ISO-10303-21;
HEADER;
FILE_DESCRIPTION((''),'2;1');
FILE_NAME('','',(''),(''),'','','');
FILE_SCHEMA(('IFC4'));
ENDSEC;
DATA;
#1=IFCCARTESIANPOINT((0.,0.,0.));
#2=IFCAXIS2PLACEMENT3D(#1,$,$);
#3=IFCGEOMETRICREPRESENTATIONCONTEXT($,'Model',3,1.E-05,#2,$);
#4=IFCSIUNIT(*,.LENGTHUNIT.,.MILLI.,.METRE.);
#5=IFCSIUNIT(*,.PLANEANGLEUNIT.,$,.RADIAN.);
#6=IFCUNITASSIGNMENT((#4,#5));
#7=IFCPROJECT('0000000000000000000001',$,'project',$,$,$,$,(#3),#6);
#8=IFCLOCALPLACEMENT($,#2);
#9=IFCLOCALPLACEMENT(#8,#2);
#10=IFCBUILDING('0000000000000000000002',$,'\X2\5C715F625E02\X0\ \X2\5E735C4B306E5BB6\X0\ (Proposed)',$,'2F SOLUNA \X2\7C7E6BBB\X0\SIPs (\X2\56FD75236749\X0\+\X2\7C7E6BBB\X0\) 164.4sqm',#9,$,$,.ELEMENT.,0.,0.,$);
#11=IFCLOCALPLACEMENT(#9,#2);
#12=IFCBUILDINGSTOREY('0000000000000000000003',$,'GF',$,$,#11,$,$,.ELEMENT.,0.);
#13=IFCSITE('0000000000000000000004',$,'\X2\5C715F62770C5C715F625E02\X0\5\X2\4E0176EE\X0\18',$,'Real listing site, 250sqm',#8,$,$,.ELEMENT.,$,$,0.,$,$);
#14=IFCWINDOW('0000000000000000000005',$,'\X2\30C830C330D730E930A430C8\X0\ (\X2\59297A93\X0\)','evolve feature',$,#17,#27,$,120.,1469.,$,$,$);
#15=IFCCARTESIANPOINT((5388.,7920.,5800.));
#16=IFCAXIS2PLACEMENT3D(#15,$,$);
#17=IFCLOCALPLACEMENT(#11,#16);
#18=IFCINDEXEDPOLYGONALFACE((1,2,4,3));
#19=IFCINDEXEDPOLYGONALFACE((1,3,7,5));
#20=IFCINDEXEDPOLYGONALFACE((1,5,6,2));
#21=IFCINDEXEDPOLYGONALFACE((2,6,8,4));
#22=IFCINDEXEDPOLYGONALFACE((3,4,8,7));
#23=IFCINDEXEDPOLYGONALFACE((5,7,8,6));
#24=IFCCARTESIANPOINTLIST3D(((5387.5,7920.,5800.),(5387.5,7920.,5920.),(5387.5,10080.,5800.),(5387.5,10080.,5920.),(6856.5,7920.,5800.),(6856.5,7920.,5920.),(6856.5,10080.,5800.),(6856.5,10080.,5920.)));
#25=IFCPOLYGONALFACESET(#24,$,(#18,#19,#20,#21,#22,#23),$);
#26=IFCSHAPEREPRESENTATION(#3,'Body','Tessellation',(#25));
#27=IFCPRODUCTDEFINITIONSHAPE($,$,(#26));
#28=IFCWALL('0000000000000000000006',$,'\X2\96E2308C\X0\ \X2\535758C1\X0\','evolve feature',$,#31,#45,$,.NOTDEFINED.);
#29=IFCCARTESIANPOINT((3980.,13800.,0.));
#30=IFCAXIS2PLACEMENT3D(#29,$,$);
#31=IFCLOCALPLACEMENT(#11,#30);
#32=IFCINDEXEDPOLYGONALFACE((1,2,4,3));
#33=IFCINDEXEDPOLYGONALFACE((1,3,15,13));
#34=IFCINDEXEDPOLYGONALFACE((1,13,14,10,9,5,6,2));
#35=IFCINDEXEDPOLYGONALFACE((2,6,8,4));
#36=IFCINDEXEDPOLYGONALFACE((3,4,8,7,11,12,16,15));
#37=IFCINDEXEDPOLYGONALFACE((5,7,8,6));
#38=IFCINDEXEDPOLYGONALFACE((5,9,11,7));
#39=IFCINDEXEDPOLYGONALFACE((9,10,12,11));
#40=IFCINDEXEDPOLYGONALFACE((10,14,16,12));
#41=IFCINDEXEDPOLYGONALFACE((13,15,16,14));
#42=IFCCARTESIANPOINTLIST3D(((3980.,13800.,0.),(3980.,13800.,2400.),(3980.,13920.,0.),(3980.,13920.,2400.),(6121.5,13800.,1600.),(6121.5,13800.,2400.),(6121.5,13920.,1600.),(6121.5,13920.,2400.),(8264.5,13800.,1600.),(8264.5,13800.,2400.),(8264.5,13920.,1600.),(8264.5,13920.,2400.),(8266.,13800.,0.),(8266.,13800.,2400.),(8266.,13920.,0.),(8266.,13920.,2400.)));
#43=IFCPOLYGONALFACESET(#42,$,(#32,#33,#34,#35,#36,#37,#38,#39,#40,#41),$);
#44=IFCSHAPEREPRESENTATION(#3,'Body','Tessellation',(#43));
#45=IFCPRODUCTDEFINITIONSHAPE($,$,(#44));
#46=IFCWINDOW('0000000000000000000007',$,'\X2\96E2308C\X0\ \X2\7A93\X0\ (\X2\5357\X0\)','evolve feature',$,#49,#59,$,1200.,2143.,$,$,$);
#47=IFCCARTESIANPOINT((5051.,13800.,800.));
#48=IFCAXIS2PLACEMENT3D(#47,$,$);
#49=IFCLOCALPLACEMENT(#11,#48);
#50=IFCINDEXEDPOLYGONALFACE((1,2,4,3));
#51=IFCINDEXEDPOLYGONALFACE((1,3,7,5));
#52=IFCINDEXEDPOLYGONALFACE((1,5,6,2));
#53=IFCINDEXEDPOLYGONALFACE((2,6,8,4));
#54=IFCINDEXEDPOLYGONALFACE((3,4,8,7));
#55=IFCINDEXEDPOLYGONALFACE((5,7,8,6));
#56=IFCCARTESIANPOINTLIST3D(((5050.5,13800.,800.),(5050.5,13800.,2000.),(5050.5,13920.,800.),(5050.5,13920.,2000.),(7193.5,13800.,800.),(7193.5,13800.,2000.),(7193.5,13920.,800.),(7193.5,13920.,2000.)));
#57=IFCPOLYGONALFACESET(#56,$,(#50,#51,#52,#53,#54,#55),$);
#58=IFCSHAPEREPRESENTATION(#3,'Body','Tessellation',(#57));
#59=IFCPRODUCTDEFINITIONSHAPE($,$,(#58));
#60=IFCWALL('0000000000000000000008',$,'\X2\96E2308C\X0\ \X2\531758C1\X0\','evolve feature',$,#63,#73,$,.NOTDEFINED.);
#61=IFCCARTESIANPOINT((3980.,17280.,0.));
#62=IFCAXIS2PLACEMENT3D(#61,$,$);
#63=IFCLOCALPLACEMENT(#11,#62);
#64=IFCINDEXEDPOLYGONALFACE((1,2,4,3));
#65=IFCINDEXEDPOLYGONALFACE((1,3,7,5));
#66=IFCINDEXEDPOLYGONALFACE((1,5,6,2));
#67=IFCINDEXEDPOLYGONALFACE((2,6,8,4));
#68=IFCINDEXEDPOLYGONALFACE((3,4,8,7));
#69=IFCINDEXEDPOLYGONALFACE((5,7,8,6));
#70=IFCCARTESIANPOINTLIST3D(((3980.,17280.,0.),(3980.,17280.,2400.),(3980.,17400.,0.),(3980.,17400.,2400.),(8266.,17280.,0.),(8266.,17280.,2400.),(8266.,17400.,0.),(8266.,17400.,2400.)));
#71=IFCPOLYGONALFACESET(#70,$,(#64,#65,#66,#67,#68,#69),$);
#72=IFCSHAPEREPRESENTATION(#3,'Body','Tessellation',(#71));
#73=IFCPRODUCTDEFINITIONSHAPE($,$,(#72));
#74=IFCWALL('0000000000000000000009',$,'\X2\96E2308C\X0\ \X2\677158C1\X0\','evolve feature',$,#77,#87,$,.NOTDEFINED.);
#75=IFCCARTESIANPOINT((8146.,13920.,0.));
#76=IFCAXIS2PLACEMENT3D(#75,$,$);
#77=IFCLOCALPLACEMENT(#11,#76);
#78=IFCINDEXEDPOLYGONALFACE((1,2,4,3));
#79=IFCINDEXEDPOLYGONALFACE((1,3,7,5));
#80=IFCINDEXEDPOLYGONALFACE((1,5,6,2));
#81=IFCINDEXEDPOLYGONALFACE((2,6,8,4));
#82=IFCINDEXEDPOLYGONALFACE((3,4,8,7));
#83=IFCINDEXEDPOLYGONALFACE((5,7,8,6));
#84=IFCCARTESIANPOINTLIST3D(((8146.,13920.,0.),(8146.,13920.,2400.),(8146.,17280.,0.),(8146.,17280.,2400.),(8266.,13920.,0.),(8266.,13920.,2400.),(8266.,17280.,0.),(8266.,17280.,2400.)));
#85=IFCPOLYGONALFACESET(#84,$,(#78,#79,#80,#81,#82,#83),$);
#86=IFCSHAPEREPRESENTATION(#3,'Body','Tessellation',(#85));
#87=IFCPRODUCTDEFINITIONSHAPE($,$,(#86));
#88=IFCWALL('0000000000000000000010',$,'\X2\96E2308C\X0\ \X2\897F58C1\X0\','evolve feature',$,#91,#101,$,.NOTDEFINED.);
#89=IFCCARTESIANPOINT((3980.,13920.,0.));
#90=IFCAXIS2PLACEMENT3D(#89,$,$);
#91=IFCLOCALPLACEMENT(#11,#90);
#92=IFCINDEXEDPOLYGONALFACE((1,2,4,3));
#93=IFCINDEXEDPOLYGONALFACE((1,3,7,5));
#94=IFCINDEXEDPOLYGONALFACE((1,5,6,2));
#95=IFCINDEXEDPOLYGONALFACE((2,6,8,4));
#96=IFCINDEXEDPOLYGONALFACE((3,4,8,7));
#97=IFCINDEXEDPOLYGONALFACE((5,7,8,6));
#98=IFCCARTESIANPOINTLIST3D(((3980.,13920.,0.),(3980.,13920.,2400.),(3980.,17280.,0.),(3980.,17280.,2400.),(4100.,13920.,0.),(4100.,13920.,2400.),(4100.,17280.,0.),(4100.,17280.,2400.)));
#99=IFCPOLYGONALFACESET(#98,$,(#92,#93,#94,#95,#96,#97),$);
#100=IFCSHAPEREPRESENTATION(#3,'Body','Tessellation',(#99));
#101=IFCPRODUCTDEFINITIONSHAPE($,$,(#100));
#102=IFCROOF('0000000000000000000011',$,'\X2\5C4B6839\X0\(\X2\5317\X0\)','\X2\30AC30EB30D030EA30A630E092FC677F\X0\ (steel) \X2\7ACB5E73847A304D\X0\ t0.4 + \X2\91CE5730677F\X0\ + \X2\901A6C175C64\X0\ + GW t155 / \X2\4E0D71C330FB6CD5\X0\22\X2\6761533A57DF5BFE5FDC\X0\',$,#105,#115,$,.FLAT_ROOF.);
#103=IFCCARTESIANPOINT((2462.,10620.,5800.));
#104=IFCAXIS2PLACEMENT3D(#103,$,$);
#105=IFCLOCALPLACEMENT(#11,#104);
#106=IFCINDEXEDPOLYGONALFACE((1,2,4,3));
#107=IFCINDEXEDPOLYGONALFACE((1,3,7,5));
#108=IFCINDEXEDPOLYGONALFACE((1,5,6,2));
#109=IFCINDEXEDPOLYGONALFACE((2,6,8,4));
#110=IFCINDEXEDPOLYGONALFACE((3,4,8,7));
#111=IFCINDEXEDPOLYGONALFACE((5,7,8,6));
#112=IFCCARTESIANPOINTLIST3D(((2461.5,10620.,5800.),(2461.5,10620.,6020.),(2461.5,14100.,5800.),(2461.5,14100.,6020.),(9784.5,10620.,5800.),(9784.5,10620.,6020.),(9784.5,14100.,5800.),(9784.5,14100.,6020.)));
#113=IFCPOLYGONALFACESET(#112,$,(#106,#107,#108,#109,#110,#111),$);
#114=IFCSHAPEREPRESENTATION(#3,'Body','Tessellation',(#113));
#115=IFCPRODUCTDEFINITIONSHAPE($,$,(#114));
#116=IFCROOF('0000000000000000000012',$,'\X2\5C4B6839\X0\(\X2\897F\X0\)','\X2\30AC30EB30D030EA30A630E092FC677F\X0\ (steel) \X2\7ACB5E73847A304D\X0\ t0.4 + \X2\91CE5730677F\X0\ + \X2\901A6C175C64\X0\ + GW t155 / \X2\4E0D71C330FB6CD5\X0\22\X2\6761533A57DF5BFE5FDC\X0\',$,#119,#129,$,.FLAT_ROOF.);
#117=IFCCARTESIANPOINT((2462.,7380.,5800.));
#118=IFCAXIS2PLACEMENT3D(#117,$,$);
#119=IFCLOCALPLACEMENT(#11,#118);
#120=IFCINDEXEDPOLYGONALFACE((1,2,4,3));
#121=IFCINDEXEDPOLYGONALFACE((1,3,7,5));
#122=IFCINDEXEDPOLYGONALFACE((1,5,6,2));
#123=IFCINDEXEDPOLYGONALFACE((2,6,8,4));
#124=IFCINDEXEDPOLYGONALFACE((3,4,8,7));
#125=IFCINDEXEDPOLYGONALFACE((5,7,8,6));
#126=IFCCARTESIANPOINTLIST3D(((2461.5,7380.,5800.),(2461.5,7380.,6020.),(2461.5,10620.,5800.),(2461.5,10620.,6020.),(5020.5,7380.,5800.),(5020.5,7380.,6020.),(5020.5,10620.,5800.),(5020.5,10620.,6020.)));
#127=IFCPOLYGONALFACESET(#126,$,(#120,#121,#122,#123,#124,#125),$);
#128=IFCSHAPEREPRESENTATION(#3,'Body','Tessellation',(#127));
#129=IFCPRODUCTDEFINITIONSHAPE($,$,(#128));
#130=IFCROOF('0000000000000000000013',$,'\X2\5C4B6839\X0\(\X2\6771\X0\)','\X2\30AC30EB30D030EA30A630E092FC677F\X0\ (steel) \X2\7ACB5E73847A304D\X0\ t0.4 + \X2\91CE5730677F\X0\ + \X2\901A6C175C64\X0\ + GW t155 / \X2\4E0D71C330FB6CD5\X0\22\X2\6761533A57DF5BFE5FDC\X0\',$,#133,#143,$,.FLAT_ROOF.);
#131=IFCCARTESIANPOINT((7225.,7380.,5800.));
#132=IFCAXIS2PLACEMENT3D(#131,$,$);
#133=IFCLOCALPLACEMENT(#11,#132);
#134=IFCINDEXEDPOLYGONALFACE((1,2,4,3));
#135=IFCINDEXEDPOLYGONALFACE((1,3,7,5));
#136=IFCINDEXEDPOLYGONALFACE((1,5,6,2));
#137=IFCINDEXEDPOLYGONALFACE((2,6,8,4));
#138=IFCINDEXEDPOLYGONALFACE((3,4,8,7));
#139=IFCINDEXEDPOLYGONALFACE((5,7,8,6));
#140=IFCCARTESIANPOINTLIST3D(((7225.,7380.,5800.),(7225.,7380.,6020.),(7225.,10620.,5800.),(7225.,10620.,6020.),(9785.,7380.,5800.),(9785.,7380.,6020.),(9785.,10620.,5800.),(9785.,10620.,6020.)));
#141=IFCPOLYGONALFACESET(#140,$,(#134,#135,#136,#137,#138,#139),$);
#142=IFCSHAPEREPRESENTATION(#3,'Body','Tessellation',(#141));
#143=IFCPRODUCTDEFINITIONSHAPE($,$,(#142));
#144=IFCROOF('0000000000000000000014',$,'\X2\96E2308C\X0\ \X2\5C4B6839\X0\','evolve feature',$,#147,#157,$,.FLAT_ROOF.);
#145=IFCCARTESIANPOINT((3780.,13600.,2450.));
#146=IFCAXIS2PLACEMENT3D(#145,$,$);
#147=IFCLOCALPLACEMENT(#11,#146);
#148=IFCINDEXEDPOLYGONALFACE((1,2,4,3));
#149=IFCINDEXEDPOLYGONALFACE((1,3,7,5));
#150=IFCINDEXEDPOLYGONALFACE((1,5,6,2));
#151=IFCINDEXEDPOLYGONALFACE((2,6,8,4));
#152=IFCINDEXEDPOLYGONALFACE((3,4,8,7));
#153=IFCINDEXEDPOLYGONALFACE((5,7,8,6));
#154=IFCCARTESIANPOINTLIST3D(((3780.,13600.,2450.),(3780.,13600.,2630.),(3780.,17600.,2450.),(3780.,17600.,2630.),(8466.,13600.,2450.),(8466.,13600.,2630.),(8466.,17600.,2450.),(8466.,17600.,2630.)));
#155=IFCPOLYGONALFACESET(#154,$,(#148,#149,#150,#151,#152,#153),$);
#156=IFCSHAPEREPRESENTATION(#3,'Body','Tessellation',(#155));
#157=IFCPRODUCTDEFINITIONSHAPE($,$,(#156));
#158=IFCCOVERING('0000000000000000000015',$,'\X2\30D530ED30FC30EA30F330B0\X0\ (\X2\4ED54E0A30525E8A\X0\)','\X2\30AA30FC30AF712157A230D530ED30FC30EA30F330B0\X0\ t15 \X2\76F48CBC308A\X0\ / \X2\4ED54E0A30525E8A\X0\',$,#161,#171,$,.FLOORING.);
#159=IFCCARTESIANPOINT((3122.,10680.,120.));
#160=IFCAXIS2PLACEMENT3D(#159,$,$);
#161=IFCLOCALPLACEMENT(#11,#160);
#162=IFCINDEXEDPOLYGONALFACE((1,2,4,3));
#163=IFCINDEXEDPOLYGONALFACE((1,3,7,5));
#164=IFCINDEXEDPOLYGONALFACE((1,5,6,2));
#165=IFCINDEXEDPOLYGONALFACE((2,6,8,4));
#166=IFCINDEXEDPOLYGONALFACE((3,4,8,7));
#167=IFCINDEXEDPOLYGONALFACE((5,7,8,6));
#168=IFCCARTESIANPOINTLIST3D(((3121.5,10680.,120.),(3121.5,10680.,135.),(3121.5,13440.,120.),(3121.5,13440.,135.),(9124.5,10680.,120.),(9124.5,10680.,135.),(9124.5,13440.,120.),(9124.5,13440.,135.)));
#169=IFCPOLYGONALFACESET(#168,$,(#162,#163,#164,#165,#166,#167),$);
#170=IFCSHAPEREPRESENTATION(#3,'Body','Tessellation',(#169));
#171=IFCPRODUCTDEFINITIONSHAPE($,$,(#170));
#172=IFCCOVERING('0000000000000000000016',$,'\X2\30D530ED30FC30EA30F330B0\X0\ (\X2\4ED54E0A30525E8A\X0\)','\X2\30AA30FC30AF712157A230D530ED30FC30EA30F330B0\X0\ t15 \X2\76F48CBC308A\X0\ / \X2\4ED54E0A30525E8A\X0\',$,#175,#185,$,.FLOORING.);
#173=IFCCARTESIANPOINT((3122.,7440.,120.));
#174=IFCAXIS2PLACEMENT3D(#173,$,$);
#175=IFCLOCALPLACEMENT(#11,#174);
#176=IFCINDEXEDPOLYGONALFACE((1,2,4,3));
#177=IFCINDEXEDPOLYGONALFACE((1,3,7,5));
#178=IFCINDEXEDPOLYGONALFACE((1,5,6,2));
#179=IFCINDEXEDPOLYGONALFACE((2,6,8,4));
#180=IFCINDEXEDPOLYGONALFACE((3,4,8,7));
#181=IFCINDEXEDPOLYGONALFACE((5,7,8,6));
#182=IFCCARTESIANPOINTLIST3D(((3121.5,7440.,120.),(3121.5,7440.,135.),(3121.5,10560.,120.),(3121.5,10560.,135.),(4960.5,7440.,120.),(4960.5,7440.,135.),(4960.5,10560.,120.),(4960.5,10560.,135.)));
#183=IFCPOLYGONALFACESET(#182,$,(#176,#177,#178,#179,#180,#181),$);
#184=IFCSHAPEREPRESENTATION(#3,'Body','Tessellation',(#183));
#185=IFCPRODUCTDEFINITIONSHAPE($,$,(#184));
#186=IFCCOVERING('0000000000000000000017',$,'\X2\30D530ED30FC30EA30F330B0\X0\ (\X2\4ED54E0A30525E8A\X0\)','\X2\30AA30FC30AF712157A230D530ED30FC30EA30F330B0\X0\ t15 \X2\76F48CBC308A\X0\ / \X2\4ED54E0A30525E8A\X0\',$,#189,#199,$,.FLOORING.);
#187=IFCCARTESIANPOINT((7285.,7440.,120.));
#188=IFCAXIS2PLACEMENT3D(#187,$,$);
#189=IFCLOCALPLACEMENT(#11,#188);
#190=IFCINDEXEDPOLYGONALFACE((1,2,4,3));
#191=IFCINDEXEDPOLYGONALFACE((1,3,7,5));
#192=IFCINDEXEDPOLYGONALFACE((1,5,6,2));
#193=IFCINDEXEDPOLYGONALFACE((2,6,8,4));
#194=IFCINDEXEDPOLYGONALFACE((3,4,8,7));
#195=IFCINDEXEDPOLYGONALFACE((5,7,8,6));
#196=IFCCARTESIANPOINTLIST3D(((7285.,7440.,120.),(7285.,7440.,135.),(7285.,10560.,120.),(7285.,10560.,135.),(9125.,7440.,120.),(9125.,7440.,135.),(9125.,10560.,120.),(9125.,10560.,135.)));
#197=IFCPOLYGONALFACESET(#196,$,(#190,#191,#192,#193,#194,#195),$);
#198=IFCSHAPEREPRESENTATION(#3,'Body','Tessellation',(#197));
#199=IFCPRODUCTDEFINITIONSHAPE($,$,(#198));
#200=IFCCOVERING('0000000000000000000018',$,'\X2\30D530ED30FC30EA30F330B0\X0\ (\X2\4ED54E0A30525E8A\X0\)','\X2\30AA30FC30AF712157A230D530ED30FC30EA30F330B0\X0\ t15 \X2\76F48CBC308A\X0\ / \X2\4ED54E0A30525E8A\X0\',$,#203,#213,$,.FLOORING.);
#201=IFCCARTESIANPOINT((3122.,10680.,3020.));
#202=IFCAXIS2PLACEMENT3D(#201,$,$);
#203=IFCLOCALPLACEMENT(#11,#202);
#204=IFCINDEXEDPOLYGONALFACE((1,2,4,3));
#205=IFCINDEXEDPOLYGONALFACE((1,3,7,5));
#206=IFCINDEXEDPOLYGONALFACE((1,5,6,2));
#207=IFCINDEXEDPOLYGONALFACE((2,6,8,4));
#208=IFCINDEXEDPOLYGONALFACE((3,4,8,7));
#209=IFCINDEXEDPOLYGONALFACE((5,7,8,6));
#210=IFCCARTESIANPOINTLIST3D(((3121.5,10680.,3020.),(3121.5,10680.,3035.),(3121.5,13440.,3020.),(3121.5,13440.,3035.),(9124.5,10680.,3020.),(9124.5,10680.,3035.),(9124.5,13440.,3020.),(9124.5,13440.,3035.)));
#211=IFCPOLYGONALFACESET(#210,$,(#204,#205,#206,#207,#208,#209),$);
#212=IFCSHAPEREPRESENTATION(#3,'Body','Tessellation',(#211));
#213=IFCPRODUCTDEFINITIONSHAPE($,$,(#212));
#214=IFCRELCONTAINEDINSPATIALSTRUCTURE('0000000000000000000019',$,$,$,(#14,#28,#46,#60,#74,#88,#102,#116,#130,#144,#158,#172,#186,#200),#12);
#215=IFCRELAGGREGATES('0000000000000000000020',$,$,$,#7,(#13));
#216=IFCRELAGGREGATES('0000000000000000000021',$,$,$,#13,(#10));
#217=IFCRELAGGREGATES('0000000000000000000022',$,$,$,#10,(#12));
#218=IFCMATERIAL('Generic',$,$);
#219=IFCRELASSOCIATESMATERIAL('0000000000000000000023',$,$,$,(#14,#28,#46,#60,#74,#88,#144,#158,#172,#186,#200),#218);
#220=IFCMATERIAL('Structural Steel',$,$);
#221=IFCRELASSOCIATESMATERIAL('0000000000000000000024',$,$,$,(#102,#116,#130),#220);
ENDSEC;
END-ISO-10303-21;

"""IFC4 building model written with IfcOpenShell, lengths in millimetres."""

from ifc_helpers import new_model, si_unit, frame, frame_2d, origin, place, context, project, spatial, rectangle, extrude, material, element, fill, save


model = new_model("IFC4")

# Units and contexts
model_context = context("Model", 3, precision=1e-05, world=origin())
ifc_project = project(units=[si_unit("LENGTHUNIT", "METRE", prefix="MILLI"), si_unit("PLANEANGLEUNIT", "RADIAN")], contexts=[model_context])

# Site, building, storey
site_placement = place(None, origin())
site = spatial("IfcSite", under=ifc_project, at=site_placement, Name="山形県山形市5丁目18", ObjectType="Real listing site, 250sqm", CompositionType="ELEMENT", RefElevation=0.0)
building_placement = place(site_placement, origin())
building = spatial("IfcBuilding", under=site, at=building_placement, Name="山形市 平屋の家 (Proposed)", ObjectType="2F SOLUNA 籾殻SIPs (国産杉+籾殻) 164.4sqm", CompositionType="ELEMENT", ElevationOfRefHeight=0.0, ElevationOfTerrain=0.0)
storey_placement = place(building_placement, origin())
storey = spatial("IfcBuildingStorey", under=building, at=storey_placement, Name="GF", CompositionType="ELEMENT", Elevation=0.0)

# Shared definitions
ifc_material_1 = material(Name="Generic")

# Window
window_1_placement = place(storey_placement, frame((5388.0, 7920.0, 5800.0)))
element("IfcWindow", 1, at=window_1_placement, inside=storey, material=ifc_material_1, Name="トップライト (天窓)", Description="evolve feature", OverallHeight=120.0, OverallWidth=1469.0, context=model_context, shape_type="SweptSolid", body=[
    extrude(rectangle(XDim=1469.0, YDim=2160.0, at=frame_2d((734.0, 1080.0))), frame((5388.0, 7920.0, 5800.0)), (0.0, 0.0, 1.0), 120.0),
])

# Wall, opening, window
wall_1_placement = place(storey_placement, frame((3980.0, 13800.0, 0.0)))
wall_1 = element("IfcWall", 2, at=wall_1_placement, inside=storey, material=ifc_material_1, Name="離れ 南壁", Description="evolve feature", PredefinedType="NOTDEFINED", context=model_context, shape_type="SweptSolid", body=[
    extrude(rectangle(XDim=4286.0, YDim=120.0, at=frame_2d((2143.0, 60.0))), frame((3980.0, 13800.0, 0.0)), (0.0, 0.0, 1.0), 2400.0),
])
opening_1_placement = place(storey_placement, frame((5051.0, 13800.0, 800.0)))
opening_1 = element("IfcOpeningElement", 3, at=opening_1_placement, cuts=wall_1, PredefinedType="NOTDEFINED", context=model_context, shape_type="SweptSolid", body=[
    extrude(rectangle(XDim=2143.0, YDim=120.0, at=frame_2d((1071.0, 60.0))), frame((5051.0, 13800.0, 800.0)), (0.0, 0.0, 1.0), 1200.0),
])
window_2_placement = place(storey_placement, frame((5051.0, 13800.0, 800.0)))
window_2 = element("IfcWindow", 4, at=window_2_placement, inside=storey, material=ifc_material_1, Name="離れ 窓 (南)", Description="evolve feature", OverallHeight=1200.0, OverallWidth=2143.0, context=model_context, shape_type="SweptSolid", body=[
    extrude(rectangle(XDim=2143.0, YDim=120.0, at=frame_2d((1071.0, 60.0))), frame((5051.0, 13800.0, 800.0)), (0.0, 0.0, 1.0), 1200.0),
])
fill(opening_1, window_2)

# Walls
wall_2_placement = place(storey_placement, frame((3980.0, 17280.0, 0.0)))
element("IfcWall", 5, at=wall_2_placement, inside=storey, material=ifc_material_1, Name="離れ 北壁", Description="evolve feature", PredefinedType="NOTDEFINED", context=model_context, shape_type="SweptSolid", body=[
    extrude(rectangle(XDim=4286.0, YDim=120.0, at=frame_2d((2143.0, 60.0))), frame((3980.0, 17280.0, 0.0)), (0.0, 0.0, 1.0), 2400.0),
])
wall_3_placement = place(storey_placement, frame((8146.0, 13920.0, 0.0)))
element("IfcWall", 6, at=wall_3_placement, inside=storey, material=ifc_material_1, Name="離れ 東壁", Description="evolve feature", PredefinedType="NOTDEFINED", context=model_context, shape_type="SweptSolid", body=[
    extrude(rectangle(XDim=120.0, YDim=3360.0, at=frame_2d((60.0, 1680.0))), frame((8146.0, 13920.0, 0.0)), (0.0, 0.0, 1.0), 2400.0),
])
wall_4_placement = place(storey_placement, frame((3980.0, 13920.0, 0.0)))
element("IfcWall", 7, at=wall_4_placement, inside=storey, material=ifc_material_1, Name="離れ 西壁", Description="evolve feature", PredefinedType="NOTDEFINED", context=model_context, shape_type="SweptSolid", body=[
    extrude(rectangle(XDim=120.0, YDim=3360.0, at=frame_2d((60.0, 1680.0))), frame((3980.0, 13920.0, 0.0)), (0.0, 0.0, 1.0), 2400.0),
])

# Roofs
ifc_material_2 = material(Name="Structural Steel")
for number, where, name in (
    (8, (2462.0, 10620.0, 5800.0), "屋根(北)"),
):
    element("IfcRoof", number, at=place(storey_placement, frame(where)), inside=storey, material=ifc_material_2, Name=name, Description="ガルバリウム鋼板 (steel) 立平葺き t0.4 + 野地板 + 通気層 + GW t155 / 不燃・法22条区域対応", PredefinedType="FLAT_ROOF", context=model_context, shape_type="SweptSolid", body=[
        extrude(rectangle(XDim=7323.0, YDim=3480.0, at=frame_2d((3661.0, 1740.0))), frame((2462.0, 10620.0, 5800.0)), (0.0, 0.0, 1.0), 220.0),
    ])
roof_1_placement = place(storey_placement, frame((2462.0, 7380.0, 5800.0)))
element("IfcRoof", 9, at=roof_1_placement, inside=storey, material=ifc_material_2, Name="屋根(西)", Description="ガルバリウム鋼板 (steel) 立平葺き t0.4 + 野地板 + 通気層 + GW t155 / 不燃・法22条区域対応", PredefinedType="FLAT_ROOF", context=model_context, shape_type="SweptSolid", body=[
    extrude(rectangle(XDim=2559.0, YDim=3240.0, at=frame_2d((1279.0, 1620.0))), frame((2462.0, 7380.0, 5800.0)), (0.0, 0.0, 1.0), 220.0),
])
roof_2_placement = place(storey_placement, frame((7225.0, 7380.0, 5800.0)))
element("IfcRoof", 10, at=roof_2_placement, inside=storey, material=ifc_material_2, Name="屋根(東)", Description="ガルバリウム鋼板 (steel) 立平葺き t0.4 + 野地板 + 通気層 + GW t155 / 不燃・法22条区域対応", PredefinedType="FLAT_ROOF", context=model_context, shape_type="SweptSolid", body=[
    extrude(rectangle(XDim=2560.0, YDim=3240.0, at=frame_2d((1280.0, 1620.0))), frame((7225.0, 7380.0, 5800.0)), (0.0, 0.0, 1.0), 220.0),
])
roof_3_placement = place(storey_placement, frame((3780.0, 13600.0, 2450.0)))
element("IfcRoof", 11, at=roof_3_placement, inside=storey, material=ifc_material_1, Name="離れ 屋根", Description="evolve feature", PredefinedType="FLAT_ROOF", context=model_context, shape_type="SweptSolid", body=[
    extrude(rectangle(XDim=4686.0, YDim=4000.0, at=frame_2d((2343.0, 2000.0))), frame((3780.0, 13600.0, 2450.0)), (0.0, 0.0, 1.0), 180.0),
])

# Coverings
covering_1_placement = place(storey_placement, frame((3122.0, 10680.0, 120.0)))
element("IfcCovering", 12, at=covering_1_placement, inside=storey, material=ifc_material_1, Name="フローリング (仕上げ床)", Description="オーク無垢フローリング t15 直貼り / 仕上げ床", PredefinedType="FLOORING", context=model_context, shape_type="SweptSolid", body=[
    extrude(rectangle(XDim=6003.0, YDim=2760.0, at=frame_2d((3001.0, 1380.0))), frame((3122.0, 10680.0, 120.0)), (0.0, 0.0, 1.0), 15.0),
])
covering_2_placement = place(storey_placement, frame((3122.0, 7440.0, 120.0)))
element("IfcCovering", 13, at=covering_2_placement, inside=storey, material=ifc_material_1, Name="フローリング (仕上げ床)", Description="オーク無垢フローリング t15 直貼り / 仕上げ床", PredefinedType="FLOORING", context=model_context, shape_type="SweptSolid", body=[
    extrude(rectangle(XDim=1839.0, YDim=3120.0, at=frame_2d((919.0, 1560.0))), frame((3122.0, 7440.0, 120.0)), (0.0, 0.0, 1.0), 15.0),
])
covering_3_placement = place(storey_placement, frame((7285.0, 7440.0, 120.0)))
element("IfcCovering", 14, at=covering_3_placement, inside=storey, material=ifc_material_1, Name="フローリング (仕上げ床)", Description="オーク無垢フローリング t15 直貼り / 仕上げ床", PredefinedType="FLOORING", context=model_context, shape_type="SweptSolid", body=[
    extrude(rectangle(XDim=1840.0, YDim=3120.0, at=frame_2d((920.0, 1560.0))), frame((7285.0, 7440.0, 120.0)), (0.0, 0.0, 1.0), 15.0),
])
covering_4_placement = place(storey_placement, frame((3122.0, 10680.0, 3020.0)))
element("IfcCovering", 15, at=covering_4_placement, inside=storey, material=ifc_material_1, Name="フローリング (仕上げ床)", Description="オーク無垢フローリング t15 直貼り / 仕上げ床", PredefinedType="FLOORING", context=model_context, shape_type="SweptSolid", body=[
    extrude(rectangle(XDim=6003.0, YDim=2760.0, at=frame_2d((3001.0, 1380.0))), frame((3122.0, 10680.0, 3020.0)), (0.0, 0.0, 1.0), 15.0),
])

save(model, "model.ifc")
